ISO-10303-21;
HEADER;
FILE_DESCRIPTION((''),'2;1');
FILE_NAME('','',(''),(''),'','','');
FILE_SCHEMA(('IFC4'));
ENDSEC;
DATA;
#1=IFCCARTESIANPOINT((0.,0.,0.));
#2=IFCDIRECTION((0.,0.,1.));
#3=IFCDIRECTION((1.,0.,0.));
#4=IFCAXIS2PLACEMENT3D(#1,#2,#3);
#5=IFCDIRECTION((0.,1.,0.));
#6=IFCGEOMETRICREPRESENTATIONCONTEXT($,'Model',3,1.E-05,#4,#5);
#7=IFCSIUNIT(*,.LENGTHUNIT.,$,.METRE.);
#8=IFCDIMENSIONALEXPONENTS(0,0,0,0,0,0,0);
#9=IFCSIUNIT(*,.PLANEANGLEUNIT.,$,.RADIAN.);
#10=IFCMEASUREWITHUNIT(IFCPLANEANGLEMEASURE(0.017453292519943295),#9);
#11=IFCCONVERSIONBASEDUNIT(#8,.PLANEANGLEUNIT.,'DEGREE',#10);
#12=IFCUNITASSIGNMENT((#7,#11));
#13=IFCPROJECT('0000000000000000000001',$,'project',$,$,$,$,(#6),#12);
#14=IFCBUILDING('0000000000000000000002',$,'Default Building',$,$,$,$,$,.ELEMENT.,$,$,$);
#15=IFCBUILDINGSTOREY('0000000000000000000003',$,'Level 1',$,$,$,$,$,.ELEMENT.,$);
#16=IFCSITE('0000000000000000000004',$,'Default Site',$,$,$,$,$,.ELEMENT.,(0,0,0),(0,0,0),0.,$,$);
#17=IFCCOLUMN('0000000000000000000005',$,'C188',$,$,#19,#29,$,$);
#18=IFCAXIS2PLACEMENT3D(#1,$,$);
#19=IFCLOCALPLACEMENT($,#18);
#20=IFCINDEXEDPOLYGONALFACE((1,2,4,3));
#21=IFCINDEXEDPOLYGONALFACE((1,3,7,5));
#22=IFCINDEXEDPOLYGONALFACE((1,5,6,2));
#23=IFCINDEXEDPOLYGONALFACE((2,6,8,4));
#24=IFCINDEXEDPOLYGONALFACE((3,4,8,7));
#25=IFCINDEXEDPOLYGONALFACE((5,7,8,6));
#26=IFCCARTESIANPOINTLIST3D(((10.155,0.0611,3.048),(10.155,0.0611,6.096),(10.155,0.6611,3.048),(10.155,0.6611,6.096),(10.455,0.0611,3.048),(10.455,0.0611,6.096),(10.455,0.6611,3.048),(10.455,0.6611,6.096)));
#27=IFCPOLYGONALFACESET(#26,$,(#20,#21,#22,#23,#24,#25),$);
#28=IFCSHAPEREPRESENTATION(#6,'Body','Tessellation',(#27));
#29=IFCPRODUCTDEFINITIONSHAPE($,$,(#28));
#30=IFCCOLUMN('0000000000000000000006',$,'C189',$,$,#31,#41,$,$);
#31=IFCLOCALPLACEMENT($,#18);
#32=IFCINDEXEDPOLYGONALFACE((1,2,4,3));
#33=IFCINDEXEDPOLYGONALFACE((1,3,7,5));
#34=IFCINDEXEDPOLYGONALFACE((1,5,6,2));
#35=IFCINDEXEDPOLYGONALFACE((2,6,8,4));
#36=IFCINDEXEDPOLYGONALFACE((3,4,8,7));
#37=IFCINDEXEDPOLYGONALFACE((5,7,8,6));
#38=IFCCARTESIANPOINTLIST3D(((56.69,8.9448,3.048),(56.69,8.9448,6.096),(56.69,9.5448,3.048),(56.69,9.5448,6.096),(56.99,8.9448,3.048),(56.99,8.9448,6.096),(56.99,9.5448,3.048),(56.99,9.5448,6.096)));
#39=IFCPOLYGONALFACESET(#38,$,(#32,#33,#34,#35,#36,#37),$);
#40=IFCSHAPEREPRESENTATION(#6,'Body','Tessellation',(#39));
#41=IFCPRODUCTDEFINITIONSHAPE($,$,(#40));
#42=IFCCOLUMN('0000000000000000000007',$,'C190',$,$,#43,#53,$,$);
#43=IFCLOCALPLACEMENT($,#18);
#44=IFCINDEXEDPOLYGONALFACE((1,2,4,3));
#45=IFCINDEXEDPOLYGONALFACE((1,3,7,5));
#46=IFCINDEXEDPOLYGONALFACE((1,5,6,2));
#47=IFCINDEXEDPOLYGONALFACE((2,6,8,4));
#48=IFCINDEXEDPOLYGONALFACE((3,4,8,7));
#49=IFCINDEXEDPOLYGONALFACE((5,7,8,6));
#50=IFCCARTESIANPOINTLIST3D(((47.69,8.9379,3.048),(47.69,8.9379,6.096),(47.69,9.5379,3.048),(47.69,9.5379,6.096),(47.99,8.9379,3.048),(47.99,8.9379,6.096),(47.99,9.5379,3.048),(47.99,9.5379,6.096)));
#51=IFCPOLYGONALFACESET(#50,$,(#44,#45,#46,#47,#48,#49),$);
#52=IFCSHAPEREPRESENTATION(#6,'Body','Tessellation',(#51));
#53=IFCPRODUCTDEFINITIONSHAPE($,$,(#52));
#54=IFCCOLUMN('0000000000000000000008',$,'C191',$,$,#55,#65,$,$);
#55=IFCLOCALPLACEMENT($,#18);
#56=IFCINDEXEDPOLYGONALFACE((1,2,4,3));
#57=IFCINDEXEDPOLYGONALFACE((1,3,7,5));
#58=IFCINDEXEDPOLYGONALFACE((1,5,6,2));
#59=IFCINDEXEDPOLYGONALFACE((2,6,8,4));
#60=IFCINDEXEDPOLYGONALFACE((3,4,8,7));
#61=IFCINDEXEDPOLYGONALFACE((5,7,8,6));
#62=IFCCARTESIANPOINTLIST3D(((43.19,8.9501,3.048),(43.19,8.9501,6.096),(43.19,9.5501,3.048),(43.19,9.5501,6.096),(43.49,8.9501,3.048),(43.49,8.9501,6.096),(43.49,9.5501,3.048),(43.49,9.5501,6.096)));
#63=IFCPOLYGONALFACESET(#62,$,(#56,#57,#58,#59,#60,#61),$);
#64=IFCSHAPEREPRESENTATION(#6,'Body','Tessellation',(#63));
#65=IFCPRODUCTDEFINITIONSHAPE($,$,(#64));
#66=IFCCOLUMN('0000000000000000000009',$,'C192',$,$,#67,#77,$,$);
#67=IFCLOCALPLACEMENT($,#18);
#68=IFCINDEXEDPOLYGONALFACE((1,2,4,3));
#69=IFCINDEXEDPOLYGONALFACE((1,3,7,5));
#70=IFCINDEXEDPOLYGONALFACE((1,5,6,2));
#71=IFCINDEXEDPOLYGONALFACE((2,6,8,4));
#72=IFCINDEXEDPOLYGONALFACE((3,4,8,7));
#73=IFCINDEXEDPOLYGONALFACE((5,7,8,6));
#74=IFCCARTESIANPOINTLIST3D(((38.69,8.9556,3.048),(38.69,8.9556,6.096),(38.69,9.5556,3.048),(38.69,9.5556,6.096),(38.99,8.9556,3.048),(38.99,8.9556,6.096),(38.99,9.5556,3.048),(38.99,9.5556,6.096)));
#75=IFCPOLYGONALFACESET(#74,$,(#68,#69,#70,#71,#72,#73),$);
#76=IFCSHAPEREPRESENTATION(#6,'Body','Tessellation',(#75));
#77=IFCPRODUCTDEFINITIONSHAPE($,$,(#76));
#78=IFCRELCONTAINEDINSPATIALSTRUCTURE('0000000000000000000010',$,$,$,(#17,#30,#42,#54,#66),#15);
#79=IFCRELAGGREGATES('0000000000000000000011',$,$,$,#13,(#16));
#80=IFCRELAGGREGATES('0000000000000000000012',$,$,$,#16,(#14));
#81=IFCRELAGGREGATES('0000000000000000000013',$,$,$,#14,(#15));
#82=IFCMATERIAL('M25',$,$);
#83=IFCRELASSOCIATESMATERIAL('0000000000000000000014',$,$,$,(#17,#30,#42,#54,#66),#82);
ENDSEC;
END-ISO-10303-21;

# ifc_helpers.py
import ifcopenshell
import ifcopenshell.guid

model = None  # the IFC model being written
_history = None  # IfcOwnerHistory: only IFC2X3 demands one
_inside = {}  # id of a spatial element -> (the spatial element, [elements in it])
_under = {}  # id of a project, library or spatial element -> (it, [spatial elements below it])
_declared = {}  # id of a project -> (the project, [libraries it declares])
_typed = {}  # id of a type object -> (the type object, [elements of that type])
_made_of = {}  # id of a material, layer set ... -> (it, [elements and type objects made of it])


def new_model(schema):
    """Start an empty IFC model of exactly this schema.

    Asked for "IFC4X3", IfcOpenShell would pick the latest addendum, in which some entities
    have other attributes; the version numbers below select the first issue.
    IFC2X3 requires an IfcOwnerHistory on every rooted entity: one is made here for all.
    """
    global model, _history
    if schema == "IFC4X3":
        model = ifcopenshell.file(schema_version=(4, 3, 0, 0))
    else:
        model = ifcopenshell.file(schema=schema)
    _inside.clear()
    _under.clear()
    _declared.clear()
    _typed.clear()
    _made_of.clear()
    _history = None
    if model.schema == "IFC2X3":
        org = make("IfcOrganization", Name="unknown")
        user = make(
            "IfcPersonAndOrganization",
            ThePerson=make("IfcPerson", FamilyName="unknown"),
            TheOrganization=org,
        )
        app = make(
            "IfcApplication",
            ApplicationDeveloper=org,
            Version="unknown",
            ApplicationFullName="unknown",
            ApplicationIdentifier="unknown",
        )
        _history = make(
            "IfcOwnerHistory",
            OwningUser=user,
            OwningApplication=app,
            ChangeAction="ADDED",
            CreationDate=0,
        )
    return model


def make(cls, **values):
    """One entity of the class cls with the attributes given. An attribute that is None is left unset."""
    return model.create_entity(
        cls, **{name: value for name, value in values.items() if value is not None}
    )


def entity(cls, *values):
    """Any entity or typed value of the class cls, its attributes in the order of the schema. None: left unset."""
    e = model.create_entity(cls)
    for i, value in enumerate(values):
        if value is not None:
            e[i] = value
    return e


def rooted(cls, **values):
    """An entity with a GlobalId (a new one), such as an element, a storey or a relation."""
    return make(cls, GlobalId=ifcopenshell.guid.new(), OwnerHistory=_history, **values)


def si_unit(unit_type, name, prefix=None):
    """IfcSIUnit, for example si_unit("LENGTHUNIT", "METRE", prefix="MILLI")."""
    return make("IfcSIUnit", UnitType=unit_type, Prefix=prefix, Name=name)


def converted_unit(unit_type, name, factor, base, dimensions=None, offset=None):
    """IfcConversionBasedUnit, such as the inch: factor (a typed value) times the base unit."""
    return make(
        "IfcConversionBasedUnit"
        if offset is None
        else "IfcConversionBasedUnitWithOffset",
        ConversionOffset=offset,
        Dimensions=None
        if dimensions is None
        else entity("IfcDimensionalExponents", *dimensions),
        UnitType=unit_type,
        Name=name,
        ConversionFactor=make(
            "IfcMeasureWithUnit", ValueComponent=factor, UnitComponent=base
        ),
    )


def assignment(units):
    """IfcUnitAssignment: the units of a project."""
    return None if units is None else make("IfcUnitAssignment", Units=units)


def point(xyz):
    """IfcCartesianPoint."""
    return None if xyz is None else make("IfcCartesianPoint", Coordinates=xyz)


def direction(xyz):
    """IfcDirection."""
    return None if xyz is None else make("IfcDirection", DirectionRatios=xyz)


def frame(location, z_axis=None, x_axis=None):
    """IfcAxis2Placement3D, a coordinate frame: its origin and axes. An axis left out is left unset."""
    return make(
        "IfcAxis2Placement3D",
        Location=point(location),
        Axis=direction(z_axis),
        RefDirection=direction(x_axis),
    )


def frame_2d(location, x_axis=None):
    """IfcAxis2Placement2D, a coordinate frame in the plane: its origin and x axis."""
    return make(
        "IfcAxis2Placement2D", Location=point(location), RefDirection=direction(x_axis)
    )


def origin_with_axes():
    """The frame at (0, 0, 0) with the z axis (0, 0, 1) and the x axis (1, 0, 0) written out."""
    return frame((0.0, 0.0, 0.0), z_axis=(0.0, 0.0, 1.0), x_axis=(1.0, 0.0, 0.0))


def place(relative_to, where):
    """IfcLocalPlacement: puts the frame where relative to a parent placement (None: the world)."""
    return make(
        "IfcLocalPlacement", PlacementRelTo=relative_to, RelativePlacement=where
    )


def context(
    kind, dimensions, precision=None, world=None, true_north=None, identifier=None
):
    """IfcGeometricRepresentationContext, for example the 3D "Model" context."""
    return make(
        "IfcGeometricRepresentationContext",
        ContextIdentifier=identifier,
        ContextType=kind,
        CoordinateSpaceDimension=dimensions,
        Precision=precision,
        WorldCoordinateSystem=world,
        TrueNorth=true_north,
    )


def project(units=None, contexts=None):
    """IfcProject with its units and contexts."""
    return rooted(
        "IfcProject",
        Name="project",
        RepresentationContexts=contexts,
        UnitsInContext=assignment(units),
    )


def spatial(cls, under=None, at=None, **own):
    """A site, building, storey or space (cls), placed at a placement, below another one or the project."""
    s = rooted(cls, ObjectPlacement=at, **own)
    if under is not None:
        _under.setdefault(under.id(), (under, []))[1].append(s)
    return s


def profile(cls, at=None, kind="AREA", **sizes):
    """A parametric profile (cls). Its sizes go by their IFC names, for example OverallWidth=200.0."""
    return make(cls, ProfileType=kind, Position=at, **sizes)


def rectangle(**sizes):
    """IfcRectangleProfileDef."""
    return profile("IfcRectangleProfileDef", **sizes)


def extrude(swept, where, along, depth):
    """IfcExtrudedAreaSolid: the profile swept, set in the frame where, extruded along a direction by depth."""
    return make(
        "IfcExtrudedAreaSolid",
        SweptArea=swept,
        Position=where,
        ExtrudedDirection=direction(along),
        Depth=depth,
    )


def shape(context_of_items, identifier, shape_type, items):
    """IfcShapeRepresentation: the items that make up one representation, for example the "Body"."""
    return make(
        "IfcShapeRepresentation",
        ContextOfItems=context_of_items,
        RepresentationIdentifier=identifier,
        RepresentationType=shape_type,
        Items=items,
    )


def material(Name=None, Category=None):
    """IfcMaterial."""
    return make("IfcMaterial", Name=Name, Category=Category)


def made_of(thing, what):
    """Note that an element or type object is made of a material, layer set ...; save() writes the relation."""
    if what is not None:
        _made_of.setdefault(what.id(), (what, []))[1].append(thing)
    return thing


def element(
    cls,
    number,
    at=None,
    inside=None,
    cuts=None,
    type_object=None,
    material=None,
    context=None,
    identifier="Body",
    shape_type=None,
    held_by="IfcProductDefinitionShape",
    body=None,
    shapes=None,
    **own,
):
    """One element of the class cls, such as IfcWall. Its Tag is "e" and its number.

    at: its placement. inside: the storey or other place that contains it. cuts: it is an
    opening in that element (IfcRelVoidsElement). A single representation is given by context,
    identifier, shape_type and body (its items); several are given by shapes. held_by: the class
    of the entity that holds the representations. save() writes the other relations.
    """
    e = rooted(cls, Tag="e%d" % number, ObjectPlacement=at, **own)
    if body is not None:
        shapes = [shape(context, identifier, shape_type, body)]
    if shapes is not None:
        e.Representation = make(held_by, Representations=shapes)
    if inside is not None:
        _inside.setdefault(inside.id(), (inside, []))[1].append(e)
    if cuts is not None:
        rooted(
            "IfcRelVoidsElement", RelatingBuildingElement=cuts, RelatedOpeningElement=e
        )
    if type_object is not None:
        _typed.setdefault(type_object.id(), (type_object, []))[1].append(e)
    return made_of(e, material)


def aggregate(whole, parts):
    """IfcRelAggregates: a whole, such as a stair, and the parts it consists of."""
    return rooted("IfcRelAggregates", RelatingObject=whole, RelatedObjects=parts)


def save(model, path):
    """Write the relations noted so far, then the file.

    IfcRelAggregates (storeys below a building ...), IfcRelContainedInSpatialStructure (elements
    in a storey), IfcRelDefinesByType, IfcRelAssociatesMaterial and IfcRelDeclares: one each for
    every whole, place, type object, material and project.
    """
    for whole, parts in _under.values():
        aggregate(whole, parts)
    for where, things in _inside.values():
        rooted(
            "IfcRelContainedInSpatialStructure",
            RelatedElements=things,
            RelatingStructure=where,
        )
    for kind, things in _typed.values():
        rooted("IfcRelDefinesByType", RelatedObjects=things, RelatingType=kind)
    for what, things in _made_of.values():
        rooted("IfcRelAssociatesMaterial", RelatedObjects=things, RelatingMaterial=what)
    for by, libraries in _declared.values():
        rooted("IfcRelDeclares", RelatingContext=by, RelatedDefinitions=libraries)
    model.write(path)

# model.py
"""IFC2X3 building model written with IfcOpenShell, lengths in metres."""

from ifc_helpers import new_model, entity, si_unit, converted_unit, direction, frame, frame_2d, origin_with_axes, place, context, project, spatial, rectangle, extrude, material, element, save


model = new_model("IFC2X3")

# Units and contexts
model_context = context("Model", 3, precision=1e-05, world=origin_with_axes(), true_north=direction((0.0, 1.0, 0.0)))
ifc_project = project(units=[si_unit("LENGTHUNIT", "METRE"), converted_unit("PLANEANGLEUNIT", "DEGREE", entity("IfcPlaneAngleMeasure", 0.017453292519943295), si_unit("PLANEANGLEUNIT", "RADIAN"), dimensions=[0, 0, 0, 0, 0, 0, 0])], contexts=[model_context])

# Site, building, storey
site = spatial("IfcSite", under=ifc_project, Name="Default Site", CompositionType="ELEMENT", RefLatitude=(0, 0, 0), RefLongitude=(0, 0, 0), RefElevation=0.0)
building = spatial("IfcBuilding", under=site, Name="Default Building", CompositionType="ELEMENT")
storey = spatial("IfcBuildingStorey", under=building, Name="Level 1", CompositionType="ELEMENT")

# Columns
ifc_material = material(Name="M25")
placement = place(None, origin_with_axes())
element("IfcColumn", 1, at=placement, inside=storey, material=ifc_material, Name="C188", context=model_context, shape_type="SweptSolid", body=[
    extrude(rectangle(XDim=0.3, YDim=0.6, at=frame_2d((0.0, 0.0), x_axis=(1.0, 0.0, 0.0))), frame((10.305, 0.3611, 3.048), z_axis=(0.0, 0.0, 1.0), x_axis=(1.0, 0.0, 0.0)), (0.0, 0.0, 1.0), 3.048),
])
element("IfcColumn", 2, at=placement, inside=storey, material=ifc_material, Name="C189", context=model_context, shape_type="SweptSolid", body=[
    extrude(rectangle(XDim=0.3, YDim=0.6, at=frame_2d((0.0, 0.0), x_axis=(1.0, 0.0, 0.0))), frame((56.84, 9.2448, 3.048), z_axis=(0.0, 0.0, 1.0), x_axis=(1.0, 0.0, 0.0)), (0.0, 0.0, 1.0), 3.048),
])
element("IfcColumn", 3, at=placement, inside=storey, material=ifc_material, Name="C190", context=model_context, shape_type="SweptSolid", body=[
    extrude(rectangle(XDim=0.3, YDim=0.6, at=frame_2d((0.0, 0.0), x_axis=(1.0, 0.0, 0.0))), frame((47.84, 9.2379, 3.048), z_axis=(0.0, 0.0, 1.0), x_axis=(1.0, 0.0, 0.0)), (0.0, 0.0, 1.0), 3.048),
])
element("IfcColumn", 4, at=placement, inside=storey, material=ifc_material, Name="C191", context=model_context, shape_type="SweptSolid", body=[
    extrude(rectangle(XDim=0.3, YDim=0.6, at=frame_2d((0.0, 0.0), x_axis=(1.0, 0.0, 0.0))), frame((43.34, 9.2501, 3.048), z_axis=(0.0, 0.0, 1.0), x_axis=(1.0, 0.0, 0.0)), (0.0, 0.0, 1.0), 3.048),
])
element("IfcColumn", 5, at=placement, inside=storey, material=ifc_material, Name="C192", context=model_context, shape_type="SweptSolid", body=[
    extrude(rectangle(XDim=0.3, YDim=0.6, at=frame_2d((0.0, 0.0), x_axis=(1.0, 0.0, 0.0))), frame((38.84, 9.2556, 3.048), z_axis=(0.0, 0.0, 1.0), x_axis=(1.0, 0.0, 0.0)), (0.0, 0.0, 1.0), 3.048),
])

save(model, "model.ifc")
